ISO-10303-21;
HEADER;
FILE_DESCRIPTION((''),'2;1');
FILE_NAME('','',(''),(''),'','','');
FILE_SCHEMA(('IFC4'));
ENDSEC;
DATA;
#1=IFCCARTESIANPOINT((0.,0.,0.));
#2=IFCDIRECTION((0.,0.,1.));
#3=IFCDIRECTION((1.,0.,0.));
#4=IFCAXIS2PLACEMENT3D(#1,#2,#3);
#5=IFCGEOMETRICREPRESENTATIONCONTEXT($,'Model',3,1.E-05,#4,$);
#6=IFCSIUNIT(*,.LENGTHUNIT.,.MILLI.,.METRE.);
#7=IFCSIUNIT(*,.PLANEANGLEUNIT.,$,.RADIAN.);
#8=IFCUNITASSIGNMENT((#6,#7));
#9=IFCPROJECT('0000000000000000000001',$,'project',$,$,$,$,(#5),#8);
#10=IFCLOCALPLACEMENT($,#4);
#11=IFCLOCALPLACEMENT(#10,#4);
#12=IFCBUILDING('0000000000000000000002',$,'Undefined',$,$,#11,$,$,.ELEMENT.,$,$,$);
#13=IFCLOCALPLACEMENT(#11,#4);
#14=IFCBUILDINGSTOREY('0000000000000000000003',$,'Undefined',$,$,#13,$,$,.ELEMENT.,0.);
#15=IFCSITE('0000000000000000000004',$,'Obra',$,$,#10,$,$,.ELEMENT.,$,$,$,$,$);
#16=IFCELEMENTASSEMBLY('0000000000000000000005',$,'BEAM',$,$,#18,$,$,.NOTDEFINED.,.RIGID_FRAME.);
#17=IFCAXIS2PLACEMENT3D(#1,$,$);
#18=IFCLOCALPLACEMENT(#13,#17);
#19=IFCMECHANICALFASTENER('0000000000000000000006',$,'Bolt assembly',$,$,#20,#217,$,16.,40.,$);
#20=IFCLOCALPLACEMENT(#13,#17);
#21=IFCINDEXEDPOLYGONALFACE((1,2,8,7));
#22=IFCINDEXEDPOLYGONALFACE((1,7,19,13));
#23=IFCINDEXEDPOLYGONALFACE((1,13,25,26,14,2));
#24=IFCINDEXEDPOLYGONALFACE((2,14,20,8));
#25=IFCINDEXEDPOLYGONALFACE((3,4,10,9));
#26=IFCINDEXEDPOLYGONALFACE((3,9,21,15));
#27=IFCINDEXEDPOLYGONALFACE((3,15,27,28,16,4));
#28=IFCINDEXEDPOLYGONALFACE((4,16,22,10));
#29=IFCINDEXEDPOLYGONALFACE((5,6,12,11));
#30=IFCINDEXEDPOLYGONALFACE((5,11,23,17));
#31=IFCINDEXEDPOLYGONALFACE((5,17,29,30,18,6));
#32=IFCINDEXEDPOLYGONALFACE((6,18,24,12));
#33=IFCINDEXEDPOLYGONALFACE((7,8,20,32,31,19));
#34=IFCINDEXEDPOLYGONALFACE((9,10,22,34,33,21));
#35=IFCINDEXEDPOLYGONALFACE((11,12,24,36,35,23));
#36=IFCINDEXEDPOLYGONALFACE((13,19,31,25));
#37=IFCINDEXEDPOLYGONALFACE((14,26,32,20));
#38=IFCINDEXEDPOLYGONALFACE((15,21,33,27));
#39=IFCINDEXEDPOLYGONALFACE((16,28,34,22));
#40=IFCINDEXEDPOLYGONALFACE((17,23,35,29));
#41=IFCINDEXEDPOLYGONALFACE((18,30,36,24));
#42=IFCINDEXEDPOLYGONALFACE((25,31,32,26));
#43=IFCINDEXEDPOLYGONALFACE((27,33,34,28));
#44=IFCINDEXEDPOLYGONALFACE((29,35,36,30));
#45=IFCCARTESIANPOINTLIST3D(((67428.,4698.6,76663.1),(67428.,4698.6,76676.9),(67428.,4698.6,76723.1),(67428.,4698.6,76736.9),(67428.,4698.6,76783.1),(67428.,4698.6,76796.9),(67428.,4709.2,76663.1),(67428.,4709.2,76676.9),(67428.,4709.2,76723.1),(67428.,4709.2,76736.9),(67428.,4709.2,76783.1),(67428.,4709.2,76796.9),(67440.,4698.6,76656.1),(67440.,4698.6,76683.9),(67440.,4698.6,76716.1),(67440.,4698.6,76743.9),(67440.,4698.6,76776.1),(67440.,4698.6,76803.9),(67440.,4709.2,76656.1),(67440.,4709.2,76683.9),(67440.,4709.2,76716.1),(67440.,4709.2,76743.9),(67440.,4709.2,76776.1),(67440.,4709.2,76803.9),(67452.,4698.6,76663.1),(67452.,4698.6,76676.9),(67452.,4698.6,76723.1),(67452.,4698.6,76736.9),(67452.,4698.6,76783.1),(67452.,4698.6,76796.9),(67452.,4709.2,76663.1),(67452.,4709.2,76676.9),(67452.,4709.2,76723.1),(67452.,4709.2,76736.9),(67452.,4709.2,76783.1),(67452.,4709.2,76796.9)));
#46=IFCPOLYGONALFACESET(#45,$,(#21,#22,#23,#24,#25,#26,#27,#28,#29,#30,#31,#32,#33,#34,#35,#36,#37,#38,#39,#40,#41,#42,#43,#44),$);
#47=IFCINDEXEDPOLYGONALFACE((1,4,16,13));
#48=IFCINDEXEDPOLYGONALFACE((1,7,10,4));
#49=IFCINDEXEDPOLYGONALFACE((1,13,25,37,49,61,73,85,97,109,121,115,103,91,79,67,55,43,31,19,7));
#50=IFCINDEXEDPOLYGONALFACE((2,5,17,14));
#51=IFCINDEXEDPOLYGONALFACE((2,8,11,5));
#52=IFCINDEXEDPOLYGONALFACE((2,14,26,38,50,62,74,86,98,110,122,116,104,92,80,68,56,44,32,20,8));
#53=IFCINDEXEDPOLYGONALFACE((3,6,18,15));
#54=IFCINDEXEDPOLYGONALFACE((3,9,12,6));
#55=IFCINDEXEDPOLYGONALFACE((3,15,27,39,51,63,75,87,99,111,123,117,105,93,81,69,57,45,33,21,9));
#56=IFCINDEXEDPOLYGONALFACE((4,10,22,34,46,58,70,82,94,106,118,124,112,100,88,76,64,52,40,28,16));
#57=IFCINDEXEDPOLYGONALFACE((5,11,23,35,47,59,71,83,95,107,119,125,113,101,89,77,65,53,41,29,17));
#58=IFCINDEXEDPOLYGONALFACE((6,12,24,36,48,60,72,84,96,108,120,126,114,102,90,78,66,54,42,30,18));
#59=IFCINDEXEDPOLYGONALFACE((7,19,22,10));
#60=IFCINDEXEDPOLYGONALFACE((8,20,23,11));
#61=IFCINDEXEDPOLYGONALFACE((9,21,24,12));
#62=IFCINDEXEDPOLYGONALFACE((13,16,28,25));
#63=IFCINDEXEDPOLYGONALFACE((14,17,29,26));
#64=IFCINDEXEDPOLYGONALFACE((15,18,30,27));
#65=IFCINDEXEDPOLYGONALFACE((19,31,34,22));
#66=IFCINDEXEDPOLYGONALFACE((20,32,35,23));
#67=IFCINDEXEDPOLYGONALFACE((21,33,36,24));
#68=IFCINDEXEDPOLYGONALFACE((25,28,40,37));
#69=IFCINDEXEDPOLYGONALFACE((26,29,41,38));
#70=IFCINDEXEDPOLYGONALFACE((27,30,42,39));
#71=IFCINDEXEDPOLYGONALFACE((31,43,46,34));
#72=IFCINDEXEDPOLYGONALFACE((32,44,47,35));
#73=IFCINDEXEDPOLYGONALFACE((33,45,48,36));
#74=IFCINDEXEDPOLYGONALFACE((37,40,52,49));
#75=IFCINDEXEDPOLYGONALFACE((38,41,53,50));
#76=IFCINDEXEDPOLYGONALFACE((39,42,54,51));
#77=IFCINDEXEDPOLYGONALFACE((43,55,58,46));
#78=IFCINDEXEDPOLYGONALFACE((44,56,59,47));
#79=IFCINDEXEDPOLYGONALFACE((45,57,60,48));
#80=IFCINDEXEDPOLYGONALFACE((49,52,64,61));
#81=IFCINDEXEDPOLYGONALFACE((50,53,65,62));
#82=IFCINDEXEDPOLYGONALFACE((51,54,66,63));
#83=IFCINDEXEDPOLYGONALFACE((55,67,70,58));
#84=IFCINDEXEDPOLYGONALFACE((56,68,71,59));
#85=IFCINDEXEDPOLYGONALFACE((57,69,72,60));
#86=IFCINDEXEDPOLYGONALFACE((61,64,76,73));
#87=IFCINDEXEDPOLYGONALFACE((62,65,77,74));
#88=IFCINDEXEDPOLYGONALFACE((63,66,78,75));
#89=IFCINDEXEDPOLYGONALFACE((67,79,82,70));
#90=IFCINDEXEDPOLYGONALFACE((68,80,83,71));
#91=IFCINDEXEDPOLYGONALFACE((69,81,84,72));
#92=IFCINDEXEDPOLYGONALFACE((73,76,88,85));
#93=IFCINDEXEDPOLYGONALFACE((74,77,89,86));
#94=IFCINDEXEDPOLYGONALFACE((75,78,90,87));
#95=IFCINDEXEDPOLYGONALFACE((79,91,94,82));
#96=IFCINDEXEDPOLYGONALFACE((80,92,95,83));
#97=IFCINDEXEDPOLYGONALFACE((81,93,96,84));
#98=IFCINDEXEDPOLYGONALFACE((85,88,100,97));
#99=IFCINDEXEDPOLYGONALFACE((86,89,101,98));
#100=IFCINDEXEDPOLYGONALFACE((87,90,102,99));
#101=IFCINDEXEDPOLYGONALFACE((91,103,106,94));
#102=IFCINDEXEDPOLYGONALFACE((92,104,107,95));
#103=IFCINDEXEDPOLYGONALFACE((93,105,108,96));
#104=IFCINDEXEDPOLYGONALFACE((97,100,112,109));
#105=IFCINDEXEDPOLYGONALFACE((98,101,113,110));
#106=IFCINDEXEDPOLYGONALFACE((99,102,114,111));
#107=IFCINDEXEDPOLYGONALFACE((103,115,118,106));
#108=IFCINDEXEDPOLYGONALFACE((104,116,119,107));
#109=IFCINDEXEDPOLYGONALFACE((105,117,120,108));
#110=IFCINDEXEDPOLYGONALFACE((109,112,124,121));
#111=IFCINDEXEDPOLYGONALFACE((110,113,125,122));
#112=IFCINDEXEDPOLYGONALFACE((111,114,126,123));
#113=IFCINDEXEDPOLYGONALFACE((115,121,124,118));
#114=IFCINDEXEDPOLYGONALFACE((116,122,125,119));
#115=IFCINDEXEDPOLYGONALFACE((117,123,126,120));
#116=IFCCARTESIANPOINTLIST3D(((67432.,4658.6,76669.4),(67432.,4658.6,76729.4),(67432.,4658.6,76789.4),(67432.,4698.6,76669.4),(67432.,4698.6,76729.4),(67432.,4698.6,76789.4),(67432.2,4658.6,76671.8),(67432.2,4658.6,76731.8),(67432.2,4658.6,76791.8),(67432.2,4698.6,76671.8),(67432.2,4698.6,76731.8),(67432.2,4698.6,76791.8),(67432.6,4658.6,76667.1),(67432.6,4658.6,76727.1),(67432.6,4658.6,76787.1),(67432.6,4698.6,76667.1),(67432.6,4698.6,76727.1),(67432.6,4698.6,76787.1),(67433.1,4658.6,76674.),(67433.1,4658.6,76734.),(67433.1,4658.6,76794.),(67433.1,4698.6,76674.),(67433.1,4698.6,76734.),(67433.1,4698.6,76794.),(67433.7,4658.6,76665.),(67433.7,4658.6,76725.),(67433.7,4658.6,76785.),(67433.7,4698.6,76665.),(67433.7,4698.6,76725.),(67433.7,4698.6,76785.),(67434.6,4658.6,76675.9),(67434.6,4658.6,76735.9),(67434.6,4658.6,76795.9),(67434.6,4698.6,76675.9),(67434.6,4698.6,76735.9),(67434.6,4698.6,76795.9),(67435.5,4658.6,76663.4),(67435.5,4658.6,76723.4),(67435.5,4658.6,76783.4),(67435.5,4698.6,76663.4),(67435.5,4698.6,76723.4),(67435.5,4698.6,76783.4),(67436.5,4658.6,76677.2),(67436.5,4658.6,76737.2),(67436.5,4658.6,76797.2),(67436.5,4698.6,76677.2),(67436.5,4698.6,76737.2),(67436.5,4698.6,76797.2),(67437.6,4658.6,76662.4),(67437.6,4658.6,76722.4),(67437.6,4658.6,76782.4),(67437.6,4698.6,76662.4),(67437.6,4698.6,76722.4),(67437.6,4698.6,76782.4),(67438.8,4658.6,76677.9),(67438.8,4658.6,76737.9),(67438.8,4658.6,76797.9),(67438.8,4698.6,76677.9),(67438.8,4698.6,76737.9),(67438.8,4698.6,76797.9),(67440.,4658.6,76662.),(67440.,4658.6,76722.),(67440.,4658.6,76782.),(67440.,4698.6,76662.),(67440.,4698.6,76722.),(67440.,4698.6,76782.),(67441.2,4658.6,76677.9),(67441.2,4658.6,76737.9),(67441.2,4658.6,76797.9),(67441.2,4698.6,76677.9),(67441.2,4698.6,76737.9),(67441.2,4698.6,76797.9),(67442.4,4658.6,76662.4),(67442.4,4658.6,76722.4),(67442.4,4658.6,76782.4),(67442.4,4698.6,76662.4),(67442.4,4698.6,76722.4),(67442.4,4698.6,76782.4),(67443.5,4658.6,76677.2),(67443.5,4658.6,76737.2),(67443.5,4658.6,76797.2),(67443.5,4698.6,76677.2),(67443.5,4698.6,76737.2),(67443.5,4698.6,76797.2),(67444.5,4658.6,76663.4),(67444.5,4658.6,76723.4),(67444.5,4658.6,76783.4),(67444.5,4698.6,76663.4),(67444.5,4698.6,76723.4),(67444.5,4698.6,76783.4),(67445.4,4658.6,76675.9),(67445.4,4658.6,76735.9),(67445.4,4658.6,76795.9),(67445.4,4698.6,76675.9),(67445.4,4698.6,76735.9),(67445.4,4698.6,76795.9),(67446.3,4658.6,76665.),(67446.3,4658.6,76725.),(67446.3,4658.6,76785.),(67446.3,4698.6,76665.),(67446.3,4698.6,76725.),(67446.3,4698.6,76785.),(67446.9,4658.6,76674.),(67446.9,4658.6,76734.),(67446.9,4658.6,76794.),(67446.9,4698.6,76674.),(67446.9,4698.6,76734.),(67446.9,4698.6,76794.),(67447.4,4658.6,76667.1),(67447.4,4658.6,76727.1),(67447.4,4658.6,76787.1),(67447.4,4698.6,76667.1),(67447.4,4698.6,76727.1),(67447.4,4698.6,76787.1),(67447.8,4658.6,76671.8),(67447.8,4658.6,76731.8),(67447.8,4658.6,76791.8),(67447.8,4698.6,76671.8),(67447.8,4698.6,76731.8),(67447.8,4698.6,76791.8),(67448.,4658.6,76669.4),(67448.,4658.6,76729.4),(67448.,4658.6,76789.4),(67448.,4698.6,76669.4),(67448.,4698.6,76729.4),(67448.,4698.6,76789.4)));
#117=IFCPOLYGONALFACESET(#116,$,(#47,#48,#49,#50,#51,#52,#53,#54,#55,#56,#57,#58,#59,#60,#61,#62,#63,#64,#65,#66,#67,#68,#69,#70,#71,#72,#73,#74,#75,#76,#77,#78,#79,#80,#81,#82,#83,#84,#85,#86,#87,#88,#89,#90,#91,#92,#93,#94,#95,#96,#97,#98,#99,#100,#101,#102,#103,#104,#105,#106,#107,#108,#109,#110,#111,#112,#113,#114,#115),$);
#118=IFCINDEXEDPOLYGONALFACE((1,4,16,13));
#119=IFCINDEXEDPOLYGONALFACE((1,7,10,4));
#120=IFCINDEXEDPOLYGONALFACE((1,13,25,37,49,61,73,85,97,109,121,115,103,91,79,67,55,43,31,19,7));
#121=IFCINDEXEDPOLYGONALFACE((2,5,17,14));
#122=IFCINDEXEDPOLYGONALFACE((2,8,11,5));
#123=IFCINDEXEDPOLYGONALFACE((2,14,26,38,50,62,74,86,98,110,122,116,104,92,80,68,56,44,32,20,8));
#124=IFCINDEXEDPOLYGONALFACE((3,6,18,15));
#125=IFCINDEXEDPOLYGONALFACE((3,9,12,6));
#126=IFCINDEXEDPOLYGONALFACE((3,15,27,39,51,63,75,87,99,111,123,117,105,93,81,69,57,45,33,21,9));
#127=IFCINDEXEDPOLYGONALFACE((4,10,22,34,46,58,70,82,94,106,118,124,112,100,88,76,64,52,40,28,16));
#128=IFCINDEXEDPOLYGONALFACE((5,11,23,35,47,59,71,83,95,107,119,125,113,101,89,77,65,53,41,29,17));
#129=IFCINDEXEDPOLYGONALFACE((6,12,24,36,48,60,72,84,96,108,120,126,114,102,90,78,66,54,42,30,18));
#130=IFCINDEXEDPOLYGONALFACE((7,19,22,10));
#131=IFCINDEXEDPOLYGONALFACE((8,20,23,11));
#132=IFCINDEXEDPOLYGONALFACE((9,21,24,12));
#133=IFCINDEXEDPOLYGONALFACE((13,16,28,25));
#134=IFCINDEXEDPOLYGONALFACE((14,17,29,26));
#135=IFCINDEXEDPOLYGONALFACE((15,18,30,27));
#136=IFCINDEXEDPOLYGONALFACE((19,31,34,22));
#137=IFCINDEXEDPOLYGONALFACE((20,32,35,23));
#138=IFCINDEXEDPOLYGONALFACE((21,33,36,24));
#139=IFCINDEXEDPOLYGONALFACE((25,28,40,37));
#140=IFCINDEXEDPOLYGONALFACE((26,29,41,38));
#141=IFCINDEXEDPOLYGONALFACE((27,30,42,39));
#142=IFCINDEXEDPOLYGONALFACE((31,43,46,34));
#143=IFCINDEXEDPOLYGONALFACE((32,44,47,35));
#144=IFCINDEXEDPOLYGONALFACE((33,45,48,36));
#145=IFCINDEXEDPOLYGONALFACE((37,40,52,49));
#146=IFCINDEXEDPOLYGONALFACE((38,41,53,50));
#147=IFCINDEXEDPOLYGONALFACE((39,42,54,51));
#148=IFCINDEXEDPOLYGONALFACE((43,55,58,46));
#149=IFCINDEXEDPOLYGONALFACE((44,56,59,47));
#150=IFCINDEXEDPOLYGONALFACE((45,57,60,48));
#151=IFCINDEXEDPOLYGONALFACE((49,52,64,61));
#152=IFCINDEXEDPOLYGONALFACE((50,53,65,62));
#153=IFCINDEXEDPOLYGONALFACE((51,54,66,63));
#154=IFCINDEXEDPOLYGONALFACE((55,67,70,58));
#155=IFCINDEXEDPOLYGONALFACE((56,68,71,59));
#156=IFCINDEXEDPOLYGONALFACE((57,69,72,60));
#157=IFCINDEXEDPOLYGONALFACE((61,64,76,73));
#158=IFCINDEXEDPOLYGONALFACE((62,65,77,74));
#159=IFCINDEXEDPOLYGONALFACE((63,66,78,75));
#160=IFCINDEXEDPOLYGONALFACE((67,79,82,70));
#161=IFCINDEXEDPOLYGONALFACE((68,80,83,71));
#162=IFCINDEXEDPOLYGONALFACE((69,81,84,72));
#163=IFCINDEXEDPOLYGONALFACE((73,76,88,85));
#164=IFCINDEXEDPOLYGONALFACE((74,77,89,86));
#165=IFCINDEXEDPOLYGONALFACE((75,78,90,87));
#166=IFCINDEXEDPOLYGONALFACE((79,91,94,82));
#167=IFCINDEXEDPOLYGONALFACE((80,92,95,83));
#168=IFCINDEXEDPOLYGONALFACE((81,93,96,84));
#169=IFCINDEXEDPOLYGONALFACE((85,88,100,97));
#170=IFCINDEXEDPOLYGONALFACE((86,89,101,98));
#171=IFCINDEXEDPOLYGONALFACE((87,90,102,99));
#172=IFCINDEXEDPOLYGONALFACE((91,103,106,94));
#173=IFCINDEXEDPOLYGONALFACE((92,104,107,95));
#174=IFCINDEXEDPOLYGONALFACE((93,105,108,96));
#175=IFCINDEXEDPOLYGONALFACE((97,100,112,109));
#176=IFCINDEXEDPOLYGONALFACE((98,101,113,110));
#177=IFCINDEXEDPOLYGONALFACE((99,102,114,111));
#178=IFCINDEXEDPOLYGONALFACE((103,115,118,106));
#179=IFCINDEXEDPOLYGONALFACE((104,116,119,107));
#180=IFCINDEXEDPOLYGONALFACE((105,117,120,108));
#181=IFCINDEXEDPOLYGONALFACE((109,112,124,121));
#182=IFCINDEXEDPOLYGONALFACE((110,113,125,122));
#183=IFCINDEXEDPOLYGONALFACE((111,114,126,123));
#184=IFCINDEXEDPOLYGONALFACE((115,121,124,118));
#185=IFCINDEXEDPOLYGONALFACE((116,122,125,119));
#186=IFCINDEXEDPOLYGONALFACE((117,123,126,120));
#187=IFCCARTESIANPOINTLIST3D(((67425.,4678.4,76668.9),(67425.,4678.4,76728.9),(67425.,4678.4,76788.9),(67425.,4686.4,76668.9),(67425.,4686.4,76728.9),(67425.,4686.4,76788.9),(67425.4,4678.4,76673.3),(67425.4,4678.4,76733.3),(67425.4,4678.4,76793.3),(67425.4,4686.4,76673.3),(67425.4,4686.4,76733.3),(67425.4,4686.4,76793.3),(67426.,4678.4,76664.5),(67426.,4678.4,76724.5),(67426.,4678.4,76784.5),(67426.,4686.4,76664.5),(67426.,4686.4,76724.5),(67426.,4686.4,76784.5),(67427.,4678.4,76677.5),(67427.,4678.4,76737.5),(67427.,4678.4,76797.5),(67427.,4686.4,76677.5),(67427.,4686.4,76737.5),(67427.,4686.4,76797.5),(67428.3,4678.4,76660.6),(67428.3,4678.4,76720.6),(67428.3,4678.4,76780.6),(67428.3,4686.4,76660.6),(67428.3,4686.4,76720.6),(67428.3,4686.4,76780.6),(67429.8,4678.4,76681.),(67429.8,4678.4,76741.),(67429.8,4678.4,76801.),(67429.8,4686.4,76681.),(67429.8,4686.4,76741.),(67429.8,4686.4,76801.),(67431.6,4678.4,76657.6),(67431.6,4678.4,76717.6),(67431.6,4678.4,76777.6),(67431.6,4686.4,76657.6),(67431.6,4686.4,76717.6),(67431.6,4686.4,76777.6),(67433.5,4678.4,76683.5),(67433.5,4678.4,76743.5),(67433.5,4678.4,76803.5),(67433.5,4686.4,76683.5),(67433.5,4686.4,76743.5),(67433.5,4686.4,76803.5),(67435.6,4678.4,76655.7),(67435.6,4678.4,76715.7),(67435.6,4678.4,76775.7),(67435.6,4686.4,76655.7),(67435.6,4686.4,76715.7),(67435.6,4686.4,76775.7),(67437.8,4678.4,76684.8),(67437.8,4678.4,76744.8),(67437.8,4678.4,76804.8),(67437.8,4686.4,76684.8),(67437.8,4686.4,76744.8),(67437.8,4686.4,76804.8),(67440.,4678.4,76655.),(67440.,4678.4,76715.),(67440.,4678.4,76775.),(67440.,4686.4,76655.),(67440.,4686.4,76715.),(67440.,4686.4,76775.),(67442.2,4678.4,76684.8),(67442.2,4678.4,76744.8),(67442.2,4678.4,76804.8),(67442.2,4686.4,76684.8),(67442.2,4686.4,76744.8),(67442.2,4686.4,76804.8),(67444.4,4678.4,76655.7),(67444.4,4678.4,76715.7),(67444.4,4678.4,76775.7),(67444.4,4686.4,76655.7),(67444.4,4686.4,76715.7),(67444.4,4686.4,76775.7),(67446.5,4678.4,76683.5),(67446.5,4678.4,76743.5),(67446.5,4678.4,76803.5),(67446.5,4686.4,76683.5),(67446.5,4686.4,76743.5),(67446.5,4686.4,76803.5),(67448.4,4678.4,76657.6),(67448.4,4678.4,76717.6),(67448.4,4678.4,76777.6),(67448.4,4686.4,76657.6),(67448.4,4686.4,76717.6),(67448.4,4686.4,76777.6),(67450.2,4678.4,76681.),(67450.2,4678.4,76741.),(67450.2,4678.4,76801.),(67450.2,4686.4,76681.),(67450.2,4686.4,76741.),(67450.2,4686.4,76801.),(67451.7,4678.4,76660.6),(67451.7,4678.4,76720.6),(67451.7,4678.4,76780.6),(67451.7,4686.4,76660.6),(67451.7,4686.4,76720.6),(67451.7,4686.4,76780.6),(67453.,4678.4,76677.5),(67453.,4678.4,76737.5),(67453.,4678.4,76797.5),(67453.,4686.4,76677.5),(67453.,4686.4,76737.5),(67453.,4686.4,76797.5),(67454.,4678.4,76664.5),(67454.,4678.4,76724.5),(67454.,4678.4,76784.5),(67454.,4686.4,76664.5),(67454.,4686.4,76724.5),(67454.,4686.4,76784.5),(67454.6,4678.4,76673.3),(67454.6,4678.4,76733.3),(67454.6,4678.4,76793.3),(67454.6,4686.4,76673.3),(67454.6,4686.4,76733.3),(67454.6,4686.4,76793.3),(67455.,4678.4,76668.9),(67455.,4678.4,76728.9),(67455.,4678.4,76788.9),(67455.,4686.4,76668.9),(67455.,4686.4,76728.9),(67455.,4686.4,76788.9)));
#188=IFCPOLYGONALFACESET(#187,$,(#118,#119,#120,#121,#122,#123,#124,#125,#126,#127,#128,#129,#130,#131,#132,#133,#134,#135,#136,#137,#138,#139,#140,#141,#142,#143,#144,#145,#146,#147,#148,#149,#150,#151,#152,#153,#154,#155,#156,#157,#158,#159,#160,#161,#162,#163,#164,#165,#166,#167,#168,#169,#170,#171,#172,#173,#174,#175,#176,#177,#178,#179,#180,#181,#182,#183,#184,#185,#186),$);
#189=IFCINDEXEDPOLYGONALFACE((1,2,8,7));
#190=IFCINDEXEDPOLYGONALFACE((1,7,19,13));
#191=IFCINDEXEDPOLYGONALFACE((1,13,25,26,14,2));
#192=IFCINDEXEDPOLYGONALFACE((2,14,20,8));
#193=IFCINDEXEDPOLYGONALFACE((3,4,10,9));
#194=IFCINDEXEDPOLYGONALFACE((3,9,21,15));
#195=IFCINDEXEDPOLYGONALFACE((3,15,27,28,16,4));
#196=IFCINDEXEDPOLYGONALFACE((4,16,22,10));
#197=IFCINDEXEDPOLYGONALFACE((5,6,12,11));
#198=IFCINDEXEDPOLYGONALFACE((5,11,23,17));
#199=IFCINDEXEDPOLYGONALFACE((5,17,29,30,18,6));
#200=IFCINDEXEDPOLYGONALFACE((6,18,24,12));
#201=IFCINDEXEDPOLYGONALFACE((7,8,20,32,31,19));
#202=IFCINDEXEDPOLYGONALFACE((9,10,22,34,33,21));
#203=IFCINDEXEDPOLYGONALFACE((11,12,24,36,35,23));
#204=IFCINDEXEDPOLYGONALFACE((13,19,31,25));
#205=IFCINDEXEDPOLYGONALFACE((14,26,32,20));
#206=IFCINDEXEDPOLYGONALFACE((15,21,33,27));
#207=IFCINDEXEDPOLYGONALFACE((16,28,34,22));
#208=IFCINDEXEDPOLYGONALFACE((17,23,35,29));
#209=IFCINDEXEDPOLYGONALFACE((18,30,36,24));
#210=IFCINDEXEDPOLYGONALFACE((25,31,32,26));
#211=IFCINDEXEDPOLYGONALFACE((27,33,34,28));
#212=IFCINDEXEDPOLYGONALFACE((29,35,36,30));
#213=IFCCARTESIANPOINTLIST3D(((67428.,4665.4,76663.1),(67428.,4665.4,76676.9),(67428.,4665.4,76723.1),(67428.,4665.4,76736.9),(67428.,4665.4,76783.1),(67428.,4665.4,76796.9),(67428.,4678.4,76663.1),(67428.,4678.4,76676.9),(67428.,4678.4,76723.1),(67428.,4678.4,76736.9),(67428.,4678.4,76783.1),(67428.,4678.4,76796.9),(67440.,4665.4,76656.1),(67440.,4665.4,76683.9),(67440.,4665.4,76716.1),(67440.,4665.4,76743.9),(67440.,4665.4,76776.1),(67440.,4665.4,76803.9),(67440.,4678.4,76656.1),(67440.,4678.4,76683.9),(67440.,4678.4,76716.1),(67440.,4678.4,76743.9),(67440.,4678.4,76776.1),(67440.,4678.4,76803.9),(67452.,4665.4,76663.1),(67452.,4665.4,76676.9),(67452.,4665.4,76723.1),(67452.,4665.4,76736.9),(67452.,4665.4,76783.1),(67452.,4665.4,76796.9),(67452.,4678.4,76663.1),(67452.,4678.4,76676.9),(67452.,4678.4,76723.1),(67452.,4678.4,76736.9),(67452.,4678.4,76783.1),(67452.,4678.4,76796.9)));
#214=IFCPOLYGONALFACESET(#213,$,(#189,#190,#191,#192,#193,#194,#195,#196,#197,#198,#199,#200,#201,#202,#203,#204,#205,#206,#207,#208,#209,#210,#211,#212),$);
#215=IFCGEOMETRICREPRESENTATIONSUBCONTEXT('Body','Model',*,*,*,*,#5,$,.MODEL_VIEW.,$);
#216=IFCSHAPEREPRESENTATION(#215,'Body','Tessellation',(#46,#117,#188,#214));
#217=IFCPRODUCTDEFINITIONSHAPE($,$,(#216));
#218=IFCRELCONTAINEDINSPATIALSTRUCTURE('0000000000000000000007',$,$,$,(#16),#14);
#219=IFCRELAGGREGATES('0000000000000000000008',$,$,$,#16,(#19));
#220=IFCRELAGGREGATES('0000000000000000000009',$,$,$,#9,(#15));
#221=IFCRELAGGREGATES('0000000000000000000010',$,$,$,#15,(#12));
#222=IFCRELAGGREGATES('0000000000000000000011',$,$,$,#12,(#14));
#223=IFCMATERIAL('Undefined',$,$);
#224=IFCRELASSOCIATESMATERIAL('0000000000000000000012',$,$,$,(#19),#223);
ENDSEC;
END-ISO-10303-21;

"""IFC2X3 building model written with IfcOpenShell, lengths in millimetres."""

from ifc_helpers import new_model, si_unit, frame, origin_with_axes, origin_2d_with_axis, place, context, subcontext, project, spatial, polyline, circle, outline, extrude, source, transform, mapped, material, element, aggregate, save


model = new_model("IFC2X3")

# Units and contexts
model_context = context("Model", 3, precision=1e-05, world=origin_with_axes())
body_context = subcontext(model_context, "Body", "Model", "MODEL_VIEW")
ifc_project = project(units=[si_unit("LENGTHUNIT", "METRE", prefix="MILLI"), si_unit("PLANEANGLEUNIT", "RADIAN")], contexts=[model_context])

# Site, building, storey
site_placement = place(None, origin_with_axes())
site = spatial("IfcSite", under=ifc_project, at=site_placement, Name="Obra", CompositionType="ELEMENT")
building_placement = place(site_placement, origin_with_axes())
building = spatial("IfcBuilding", under=site, at=building_placement, Name="Undefined", CompositionType="ELEMENT")
storey_placement = place(building_placement, origin_with_axes())
storey = spatial("IfcBuildingStorey", under=building, at=storey_placement, Name="Undefined", CompositionType="ELEMENT", Elevation=0.0)

# Element assembly
assembly_1_placement = place(storey_placement, origin_with_axes())
assembly_1 = element("IfcElementAssembly", 1, at=assembly_1_placement, inside=storey, Name="BEAM", AssemblyPlace="NOTDEFINED", PredefinedType="RIGID_FRAME")

# Shared definitions
ifc_material_1 = material(Name="Undefined")

# Mechanical fastener
shared_shape_1 = source(origin_with_axes(), body_context, "Body", "SweptSolid", [
    extrude(outline(polyline([(13.9, 0.0), (6.9, 12.0), (-6.9, 12.0), (-13.9, 0.0), (-6.9, -12.0), (6.9, -12.0), (13.9, 0.0)])), frame((0.0, -19.7, 0.0), z_axis=(0.0, 1.0, 0.0), x_axis=(1.0, 0.0, 0.0)), (0.0, 0.0, 1.0), 10.6),
    extrude(circle(Radius=8.0, at=origin_2d_with_axis()), frame((0.0, -9.1, 0.0), z_axis=(0.0, 1.0, 0.0), x_axis=(1.0, 0.0, 0.0)), (0.0, 0.0, 1.0), 40.0),
    extrude(circle(Radius=15.0, at=origin_2d_with_axis()), frame((0.0, 3.1, 0.0), z_axis=(0.0, 1.0, 0.0), x_axis=(1.0, 0.0, 0.0)), (0.0, 0.0, 1.0), 8.0),
    extrude(outline(polyline([(13.9, 0.0), (6.9, 12.0), (-6.9, 12.0), (-13.9, 0.0), (-6.9, -12.0), (6.9, -12.0), (13.9, 0.0)])), frame((0.0, 11.1, 0.0), z_axis=(0.0, 1.0, 0.0), x_axis=(1.0, 0.0, 0.0)), (0.0, 0.0, 1.0), 13.0),
])
mechanical_fastener_1_placement = place(assembly_1_placement, frame((67490.0, 4689.5, 76850.0), z_axis=(-1.0, 0.0, 0.0), x_axis=(0.0, 0.0, -1.0)))
mechanical_fastener_1 = element("IfcMechanicalFastener", 2, at=mechanical_fastener_1_placement, material=ifc_material_1, Name="Bolt assembly", NominalDiameter=16.0, NominalLength=40.0, context=body_context, shape_type="MappedRepresentation", body=[
    mapped(shared_shape_1, transform((60.0, 0.0, 50.0))),
    mapped(shared_shape_1, transform((120.0, 0.0, 50.0))),
    mapped(shared_shape_1, transform((180.0, 0.0, 50.0))),
])
aggregate(assembly_1, [mechanical_fastener_1])

save(model, "model.ifc")
